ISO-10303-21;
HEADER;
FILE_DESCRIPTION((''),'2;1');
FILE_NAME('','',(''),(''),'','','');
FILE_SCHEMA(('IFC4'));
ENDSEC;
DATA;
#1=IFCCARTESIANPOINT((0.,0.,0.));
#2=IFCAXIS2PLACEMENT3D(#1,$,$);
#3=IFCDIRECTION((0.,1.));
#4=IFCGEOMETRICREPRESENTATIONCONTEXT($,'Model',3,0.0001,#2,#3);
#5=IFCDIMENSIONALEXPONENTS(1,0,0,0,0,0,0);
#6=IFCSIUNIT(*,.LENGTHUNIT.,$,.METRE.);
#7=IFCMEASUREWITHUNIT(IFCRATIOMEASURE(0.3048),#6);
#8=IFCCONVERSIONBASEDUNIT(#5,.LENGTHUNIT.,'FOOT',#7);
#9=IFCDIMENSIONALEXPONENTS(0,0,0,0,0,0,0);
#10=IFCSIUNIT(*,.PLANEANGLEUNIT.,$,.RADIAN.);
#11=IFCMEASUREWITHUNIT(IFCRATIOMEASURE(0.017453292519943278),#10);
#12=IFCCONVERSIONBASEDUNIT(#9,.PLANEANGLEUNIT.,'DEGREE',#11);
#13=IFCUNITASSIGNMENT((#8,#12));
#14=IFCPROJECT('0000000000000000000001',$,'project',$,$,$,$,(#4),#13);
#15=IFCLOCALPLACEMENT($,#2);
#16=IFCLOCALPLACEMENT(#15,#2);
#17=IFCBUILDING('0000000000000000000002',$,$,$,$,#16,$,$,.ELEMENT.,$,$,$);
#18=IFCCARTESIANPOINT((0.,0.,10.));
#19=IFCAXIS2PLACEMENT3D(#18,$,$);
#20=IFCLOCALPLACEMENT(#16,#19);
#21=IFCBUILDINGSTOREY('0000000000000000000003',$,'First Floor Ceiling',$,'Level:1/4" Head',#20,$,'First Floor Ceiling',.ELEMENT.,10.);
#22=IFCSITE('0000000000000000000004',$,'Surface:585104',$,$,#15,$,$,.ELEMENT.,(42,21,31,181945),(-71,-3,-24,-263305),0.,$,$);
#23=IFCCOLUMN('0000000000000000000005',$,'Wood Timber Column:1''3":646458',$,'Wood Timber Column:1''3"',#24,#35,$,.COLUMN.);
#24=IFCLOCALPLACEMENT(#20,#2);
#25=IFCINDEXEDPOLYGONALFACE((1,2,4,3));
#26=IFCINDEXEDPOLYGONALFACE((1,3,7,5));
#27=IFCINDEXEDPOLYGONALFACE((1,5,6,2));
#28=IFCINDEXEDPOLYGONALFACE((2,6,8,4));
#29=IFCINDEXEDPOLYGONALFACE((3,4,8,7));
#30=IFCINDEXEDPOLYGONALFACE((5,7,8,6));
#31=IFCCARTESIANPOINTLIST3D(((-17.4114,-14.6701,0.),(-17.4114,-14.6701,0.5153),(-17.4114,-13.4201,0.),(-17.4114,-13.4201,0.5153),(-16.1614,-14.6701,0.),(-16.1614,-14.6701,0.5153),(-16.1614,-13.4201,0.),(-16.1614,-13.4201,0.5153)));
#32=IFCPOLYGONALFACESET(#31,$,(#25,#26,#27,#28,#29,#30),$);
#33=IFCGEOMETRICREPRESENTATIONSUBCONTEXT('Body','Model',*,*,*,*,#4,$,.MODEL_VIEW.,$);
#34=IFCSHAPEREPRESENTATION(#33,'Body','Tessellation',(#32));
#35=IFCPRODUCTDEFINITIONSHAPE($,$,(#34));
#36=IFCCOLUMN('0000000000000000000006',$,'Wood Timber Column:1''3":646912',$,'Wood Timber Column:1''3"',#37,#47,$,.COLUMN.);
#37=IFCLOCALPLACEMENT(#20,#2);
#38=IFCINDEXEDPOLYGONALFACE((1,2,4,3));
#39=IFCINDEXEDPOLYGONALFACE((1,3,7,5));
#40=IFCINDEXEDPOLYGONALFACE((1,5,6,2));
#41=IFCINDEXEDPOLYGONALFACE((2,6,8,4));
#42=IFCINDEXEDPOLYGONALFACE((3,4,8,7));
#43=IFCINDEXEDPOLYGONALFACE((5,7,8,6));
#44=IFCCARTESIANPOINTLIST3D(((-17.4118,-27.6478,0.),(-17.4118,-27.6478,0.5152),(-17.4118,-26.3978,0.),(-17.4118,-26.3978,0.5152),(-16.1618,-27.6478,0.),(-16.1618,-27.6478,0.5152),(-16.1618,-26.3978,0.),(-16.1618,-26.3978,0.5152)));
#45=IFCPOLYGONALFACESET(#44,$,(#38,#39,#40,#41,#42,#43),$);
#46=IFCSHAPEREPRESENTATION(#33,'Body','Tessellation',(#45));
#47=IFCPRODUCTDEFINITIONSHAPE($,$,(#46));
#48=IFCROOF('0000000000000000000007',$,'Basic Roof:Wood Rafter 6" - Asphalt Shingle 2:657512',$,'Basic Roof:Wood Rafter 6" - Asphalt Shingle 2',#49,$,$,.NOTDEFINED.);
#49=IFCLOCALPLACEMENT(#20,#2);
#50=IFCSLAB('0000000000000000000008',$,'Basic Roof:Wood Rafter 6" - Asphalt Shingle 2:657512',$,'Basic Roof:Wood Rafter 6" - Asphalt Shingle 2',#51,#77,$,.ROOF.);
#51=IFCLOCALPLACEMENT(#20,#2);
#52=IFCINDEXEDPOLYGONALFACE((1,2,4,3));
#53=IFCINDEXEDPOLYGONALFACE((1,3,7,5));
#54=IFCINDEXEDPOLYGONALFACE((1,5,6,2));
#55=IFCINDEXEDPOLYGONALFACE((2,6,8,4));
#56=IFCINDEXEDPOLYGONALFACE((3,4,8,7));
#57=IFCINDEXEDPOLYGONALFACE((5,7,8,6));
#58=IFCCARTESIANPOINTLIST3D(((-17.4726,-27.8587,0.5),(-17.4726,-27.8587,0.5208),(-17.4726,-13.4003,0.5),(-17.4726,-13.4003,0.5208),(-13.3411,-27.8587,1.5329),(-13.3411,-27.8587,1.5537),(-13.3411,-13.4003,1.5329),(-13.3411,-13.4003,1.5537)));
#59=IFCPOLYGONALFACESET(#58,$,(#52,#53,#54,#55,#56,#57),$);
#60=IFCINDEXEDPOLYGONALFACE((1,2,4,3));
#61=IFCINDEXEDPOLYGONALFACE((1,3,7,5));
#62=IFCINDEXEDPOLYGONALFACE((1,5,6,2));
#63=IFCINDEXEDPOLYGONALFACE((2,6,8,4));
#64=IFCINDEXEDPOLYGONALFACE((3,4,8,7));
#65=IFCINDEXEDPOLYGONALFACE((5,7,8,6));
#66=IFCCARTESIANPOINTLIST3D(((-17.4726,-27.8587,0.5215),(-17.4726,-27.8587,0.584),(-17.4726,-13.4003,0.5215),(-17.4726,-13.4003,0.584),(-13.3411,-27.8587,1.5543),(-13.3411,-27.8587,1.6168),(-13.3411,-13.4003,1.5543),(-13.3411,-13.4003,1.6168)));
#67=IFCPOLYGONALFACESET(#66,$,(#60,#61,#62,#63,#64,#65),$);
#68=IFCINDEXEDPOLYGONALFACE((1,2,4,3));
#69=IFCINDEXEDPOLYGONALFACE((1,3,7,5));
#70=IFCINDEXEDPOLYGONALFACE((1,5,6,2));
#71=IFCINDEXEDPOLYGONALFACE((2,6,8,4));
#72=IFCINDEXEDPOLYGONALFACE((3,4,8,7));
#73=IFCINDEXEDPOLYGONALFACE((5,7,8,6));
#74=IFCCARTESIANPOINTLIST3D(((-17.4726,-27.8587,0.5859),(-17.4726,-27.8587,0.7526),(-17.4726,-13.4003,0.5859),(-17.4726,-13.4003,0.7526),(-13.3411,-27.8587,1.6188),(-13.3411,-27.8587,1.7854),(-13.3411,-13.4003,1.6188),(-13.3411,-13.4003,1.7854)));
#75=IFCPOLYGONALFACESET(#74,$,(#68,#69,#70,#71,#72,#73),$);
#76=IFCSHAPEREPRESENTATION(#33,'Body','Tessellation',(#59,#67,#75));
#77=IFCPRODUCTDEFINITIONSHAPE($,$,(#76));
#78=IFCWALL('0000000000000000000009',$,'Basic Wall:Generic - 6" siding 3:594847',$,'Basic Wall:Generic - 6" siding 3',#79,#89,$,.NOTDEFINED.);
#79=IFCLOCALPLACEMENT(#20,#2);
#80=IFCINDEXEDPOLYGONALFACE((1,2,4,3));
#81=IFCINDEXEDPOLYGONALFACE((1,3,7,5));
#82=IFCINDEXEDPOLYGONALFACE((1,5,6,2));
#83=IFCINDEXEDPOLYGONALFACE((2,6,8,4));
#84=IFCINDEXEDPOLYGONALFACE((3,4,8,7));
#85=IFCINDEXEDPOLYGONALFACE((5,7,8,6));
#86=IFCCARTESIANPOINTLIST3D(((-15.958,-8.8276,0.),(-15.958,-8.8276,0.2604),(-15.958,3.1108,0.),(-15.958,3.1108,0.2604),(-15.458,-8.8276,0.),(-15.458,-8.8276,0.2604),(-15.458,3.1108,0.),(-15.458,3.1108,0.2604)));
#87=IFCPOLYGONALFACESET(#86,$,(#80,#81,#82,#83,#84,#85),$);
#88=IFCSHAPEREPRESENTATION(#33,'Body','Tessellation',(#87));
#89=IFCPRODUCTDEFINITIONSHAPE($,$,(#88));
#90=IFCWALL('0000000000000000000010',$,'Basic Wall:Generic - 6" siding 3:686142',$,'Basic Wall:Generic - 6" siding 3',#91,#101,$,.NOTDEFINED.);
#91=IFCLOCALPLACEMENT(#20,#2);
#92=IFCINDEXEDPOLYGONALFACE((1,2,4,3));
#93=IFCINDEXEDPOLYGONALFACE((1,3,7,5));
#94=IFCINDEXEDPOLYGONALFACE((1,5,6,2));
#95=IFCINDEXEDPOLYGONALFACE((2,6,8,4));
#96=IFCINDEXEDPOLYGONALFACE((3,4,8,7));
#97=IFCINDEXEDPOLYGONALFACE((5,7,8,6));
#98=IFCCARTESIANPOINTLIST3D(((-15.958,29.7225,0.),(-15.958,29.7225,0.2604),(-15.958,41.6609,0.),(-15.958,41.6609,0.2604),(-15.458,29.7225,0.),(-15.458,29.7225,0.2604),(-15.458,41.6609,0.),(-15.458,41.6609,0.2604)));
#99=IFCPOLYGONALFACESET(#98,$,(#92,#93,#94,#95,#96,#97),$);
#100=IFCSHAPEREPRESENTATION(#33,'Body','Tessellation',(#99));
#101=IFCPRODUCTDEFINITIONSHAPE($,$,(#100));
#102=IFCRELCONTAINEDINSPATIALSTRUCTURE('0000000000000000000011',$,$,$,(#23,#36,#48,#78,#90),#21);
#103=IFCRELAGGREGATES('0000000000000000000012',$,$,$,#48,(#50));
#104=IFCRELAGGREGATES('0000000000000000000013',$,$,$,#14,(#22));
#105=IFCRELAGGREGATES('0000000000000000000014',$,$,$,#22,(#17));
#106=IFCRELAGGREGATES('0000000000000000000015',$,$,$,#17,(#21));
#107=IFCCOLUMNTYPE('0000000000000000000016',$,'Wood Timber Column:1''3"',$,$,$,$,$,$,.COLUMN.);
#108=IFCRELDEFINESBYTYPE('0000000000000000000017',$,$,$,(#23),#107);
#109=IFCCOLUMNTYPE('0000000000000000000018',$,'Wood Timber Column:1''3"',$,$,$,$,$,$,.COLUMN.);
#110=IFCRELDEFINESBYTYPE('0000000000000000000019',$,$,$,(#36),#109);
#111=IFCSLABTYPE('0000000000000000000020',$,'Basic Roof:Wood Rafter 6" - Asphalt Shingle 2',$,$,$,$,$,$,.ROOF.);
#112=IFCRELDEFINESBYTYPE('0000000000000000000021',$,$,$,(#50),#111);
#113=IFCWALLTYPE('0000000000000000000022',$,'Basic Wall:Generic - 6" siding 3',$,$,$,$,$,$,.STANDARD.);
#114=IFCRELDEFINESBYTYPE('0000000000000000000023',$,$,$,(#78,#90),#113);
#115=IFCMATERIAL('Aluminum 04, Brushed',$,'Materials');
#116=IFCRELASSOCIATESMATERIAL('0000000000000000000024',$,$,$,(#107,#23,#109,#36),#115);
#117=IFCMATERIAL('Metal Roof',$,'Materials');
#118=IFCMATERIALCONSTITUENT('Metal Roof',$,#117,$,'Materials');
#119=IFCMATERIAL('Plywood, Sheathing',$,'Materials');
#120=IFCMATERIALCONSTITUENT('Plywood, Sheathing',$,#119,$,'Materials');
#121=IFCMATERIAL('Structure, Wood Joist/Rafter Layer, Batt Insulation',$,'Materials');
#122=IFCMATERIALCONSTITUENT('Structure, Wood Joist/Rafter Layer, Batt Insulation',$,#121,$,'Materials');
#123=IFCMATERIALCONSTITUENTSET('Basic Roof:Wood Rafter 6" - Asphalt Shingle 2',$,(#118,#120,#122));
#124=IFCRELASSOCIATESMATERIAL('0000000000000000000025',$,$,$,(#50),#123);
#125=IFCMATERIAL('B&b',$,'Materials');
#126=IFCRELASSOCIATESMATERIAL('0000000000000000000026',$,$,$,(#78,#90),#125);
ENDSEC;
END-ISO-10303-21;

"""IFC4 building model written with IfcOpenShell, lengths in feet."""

from ifc_helpers import new_model, entity, si_unit, converted_unit, direction, frame, origin, place, context, subcontext, project, spatial, indexed_curve, outline, extrude, source, transform, mapped, material, constituent, constituent_set, type_object, type_shapes, element, aggregate, save


model = new_model("IFC4")

# Units and contexts
model_context = context("Model", 3, precision=0.0001, world=origin(), true_north=direction((0.0, 1.0)))
body_context = subcontext(model_context, "Body", "Model", "MODEL_VIEW")
ifc_project = project(units=[converted_unit("LENGTHUNIT", "FOOT", entity("IfcRatioMeasure", 0.3048), si_unit("LENGTHUNIT", "METRE"), dimensions=[1, 0, 0, 0, 0, 0, 0]), converted_unit("PLANEANGLEUNIT", "DEGREE", entity("IfcRatioMeasure", 0.017453292519943278), si_unit("PLANEANGLEUNIT", "RADIAN"), dimensions=[0, 0, 0, 0, 0, 0, 0])], contexts=[model_context])

# Site, building, storey
site_placement = place(None, origin())
site = spatial("IfcSite", under=ifc_project, at=site_placement, Name="Surface:585104", CompositionType="ELEMENT", RefLatitude=(42, 21, 31, 181945), RefLongitude=(-71, -3, -24, -263305), RefElevation=0.0)
building_placement = place(site_placement, origin())
building = spatial("IfcBuilding", under=site, at=building_placement, CompositionType="ELEMENT")
storey_placement = place(building_placement, frame((0.0, 0.0, 10.0)))
storey = spatial("IfcBuildingStorey", under=building, at=storey_placement, Name="First Floor Ceiling", ObjectType="Level:1/4\" Head", LongName="First Floor Ceiling", CompositionType="ELEMENT", Elevation=10.0)

# Columns
ifc_material_1 = material(Name="Aluminum 04, Brushed", Category="Materials")
column_type_1 = type_object("IfcColumnType", Name="Wood Timber Column:1'3\"", PredefinedType="COLUMN", material=ifc_material_1)
shared_shape_1 = source(origin(), body_context, "Body", "SweptSolid", [
    extrude(outline(indexed_curve([(-0.625, -0.625), (0.625, -0.625), (0.625, 0.625), (-0.625, 0.625), (-0.625, -0.625)], self_intersect=False)), frame((-16.7864, -14.0451, 10.0), z_axis=(0.0, 0.0, 1.0), x_axis=(0.0, -1.0, 0.0)), (0.0, 0.0, 1.0), 0.5153),
])
type_shapes(column_type_1, [shared_shape_1])
column_1_placement = place(storey_placement, frame((0.0, 0.0, -10.0)))
element("IfcColumn", 1, at=column_1_placement, inside=storey, type_object=column_type_1, material=ifc_material_1, Name="Wood Timber Column:1'3\":646458", ObjectType="Wood Timber Column:1'3\"", PredefinedType="COLUMN", context=body_context, shape_type="MappedRepresentation", body=[
    mapped(shared_shape_1, transform((0.0, 0.0, 0.0), scale=1.0)),
])
column_type_2 = type_object("IfcColumnType", Name="Wood Timber Column:1'3\"", PredefinedType="COLUMN", material=ifc_material_1)
shared_shape_2 = source(origin(), body_context, "Body", "SweptSolid", [
    extrude(outline(indexed_curve([(-0.625, -0.625), (0.625, -0.625), (0.625, 0.625), (-0.625, 0.625), (-0.625, -0.625)], self_intersect=False)), frame((-16.7868, -27.0228, 10.0), z_axis=(0.0, 0.0, 1.0), x_axis=(0.0, -1.0, 0.0)), (0.0, 0.0, 1.0), 0.5152),
])
type_shapes(column_type_2, [shared_shape_2])
column_2_placement = place(storey_placement, frame((0.0, 0.0, -10.0)))
element("IfcColumn", 2, at=column_2_placement, inside=storey, type_object=column_type_2, material=ifc_material_1, Name="Wood Timber Column:1'3\":646912", ObjectType="Wood Timber Column:1'3\"", PredefinedType="COLUMN", context=body_context, shape_type="MappedRepresentation", body=[
    mapped(shared_shape_2, transform((0.0, 0.0, 0.0), scale=1.0)),
])

# Roof, slab
roof_placement = place(storey_placement, frame((-17.4726, -27.8587, 0.5)))
roof = element("IfcRoof", 3, at=roof_placement, inside=storey, Name="Basic Roof:Wood Rafter 6\" - Asphalt Shingle 2:657512", ObjectType="Basic Roof:Wood Rafter 6\" - Asphalt Shingle 2", PredefinedType="NOTDEFINED")
ifc_material_2 = material(Name="Metal Roof", Category="Materials")
ifc_constituent_1 = constituent(ifc_material_2, Name="Metal Roof", Category="Materials")
ifc_material_3 = material(Name="Plywood, Sheathing", Category="Materials")
ifc_constituent_2 = constituent(ifc_material_3, Name="Plywood, Sheathing", Category="Materials")
ifc_material_4 = material(Name="Structure, Wood Joist/Rafter Layer, Batt Insulation", Category="Materials")
ifc_constituent_3 = constituent(ifc_material_4, Name="Structure, Wood Joist/Rafter Layer, Batt Insulation", Category="Materials")
ifc_constituent_set = constituent_set(constituents=[ifc_constituent_1, ifc_constituent_2, ifc_constituent_3], Name="Basic Roof:Wood Rafter 6\" - Asphalt Shingle 2")
slab_type = type_object("IfcSlabType", Name="Basic Roof:Wood Rafter 6\" - Asphalt Shingle 2", PredefinedType="ROOF")
slab_placement = place(roof_placement, origin())
slab = element("IfcSlab", 4, at=slab_placement, type_object=slab_type, material=ifc_constituent_set, Name="Basic Roof:Wood Rafter 6\" - Asphalt Shingle 2:657512", ObjectType="Basic Roof:Wood Rafter 6\" - Asphalt Shingle 2", PredefinedType="ROOF", context=body_context, shape_type="SweptSolid", body=[
    extrude(outline(indexed_curve([(-2.1293, 7.2292), (-2.1293, -7.2292), (2.1293, -7.2292), (2.1293, 7.2292), (-2.1293, 7.2292)], self_intersect=False)), frame((2.0657, 7.2292, 0.5164), z_axis=(-0.242536, 0.0, 0.970143), x_axis=(0.970143, 0.0, 0.242536)), (0.242536, 0.0, 0.970143), 0.0208),
    extrude(outline(indexed_curve([(-2.1293, 7.2292), (-2.1293, -7.2292), (2.1293, -7.2292), (2.1293, 7.2292), (-2.1293, 7.2292)], self_intersect=False)), frame((2.0657, 7.2292, 0.5379), z_axis=(-0.242536, 0.0, 0.970143), x_axis=(0.970143, 0.0, 0.242536)), (0.242536, 0.0, 0.970143), 0.0625),
    extrude(outline(indexed_curve([(-2.1293, 7.2292), (-2.1293, -7.2292), (2.1293, -7.2292), (2.1293, 7.2292), (-2.1293, 7.2292)], self_intersect=False)), frame((2.0657, 7.2292, 0.6023), z_axis=(-0.242536, 0.0, 0.970143), x_axis=(0.970143, 0.0, 0.242536)), (0.242536, 0.0, 0.970143), 0.1667),
])
aggregate(roof, [slab])

# Walls
ifc_material_5 = material(Name="B&b", Category="Materials")
wall_type_1 = type_object("IfcWallType", Name="Basic Wall:Generic - 6\" siding 3", PredefinedType="STANDARD")
wall_1_placement = place(storey_placement, frame((-15.708, 3.1108, 0.0), z_axis=(0.0, 0.0, 1.0), x_axis=(0.0, -1.0, 0.0)))
element("IfcWall", 5, at=wall_1_placement, inside=storey, type_object=wall_type_1, material=ifc_material_5, Name="Basic Wall:Generic - 6\" siding 3:594847", ObjectType="Basic Wall:Generic - 6\" siding 3", PredefinedType="NOTDEFINED", context=body_context, shape_type="SweptSolid", body=[
    extrude(outline(indexed_curve([(11.9385, -0.25), (11.9385, 0.25), (0.0, 0.25), (0.0, -0.25), (11.9385, -0.25)], self_intersect=False)), origin(), (0.0, 0.0, 1.0), 0.2604),
])
wall_2_placement = place(storey_placement, frame((-15.708, 29.7225, 0.0), z_axis=(0.0, 0.0, 1.0), x_axis=(0.0, 1.0, 0.0)))
element("IfcWall", 6, at=wall_2_placement, inside=storey, type_object=wall_type_1, material=ifc_material_5, Name="Basic Wall:Generic - 6\" siding 3:686142", ObjectType="Basic Wall:Generic - 6\" siding 3", PredefinedType="NOTDEFINED", context=body_context, shape_type="SweptSolid", body=[
    extrude(outline(indexed_curve([(11.9385, -0.25), (11.9385, 0.25), (0.0, 0.25), (0.0, -0.25), (11.9385, -0.25)], self_intersect=False)), origin(), (0.0, 0.0, 1.0), 0.2604),
])

save(model, "model.ifc")
